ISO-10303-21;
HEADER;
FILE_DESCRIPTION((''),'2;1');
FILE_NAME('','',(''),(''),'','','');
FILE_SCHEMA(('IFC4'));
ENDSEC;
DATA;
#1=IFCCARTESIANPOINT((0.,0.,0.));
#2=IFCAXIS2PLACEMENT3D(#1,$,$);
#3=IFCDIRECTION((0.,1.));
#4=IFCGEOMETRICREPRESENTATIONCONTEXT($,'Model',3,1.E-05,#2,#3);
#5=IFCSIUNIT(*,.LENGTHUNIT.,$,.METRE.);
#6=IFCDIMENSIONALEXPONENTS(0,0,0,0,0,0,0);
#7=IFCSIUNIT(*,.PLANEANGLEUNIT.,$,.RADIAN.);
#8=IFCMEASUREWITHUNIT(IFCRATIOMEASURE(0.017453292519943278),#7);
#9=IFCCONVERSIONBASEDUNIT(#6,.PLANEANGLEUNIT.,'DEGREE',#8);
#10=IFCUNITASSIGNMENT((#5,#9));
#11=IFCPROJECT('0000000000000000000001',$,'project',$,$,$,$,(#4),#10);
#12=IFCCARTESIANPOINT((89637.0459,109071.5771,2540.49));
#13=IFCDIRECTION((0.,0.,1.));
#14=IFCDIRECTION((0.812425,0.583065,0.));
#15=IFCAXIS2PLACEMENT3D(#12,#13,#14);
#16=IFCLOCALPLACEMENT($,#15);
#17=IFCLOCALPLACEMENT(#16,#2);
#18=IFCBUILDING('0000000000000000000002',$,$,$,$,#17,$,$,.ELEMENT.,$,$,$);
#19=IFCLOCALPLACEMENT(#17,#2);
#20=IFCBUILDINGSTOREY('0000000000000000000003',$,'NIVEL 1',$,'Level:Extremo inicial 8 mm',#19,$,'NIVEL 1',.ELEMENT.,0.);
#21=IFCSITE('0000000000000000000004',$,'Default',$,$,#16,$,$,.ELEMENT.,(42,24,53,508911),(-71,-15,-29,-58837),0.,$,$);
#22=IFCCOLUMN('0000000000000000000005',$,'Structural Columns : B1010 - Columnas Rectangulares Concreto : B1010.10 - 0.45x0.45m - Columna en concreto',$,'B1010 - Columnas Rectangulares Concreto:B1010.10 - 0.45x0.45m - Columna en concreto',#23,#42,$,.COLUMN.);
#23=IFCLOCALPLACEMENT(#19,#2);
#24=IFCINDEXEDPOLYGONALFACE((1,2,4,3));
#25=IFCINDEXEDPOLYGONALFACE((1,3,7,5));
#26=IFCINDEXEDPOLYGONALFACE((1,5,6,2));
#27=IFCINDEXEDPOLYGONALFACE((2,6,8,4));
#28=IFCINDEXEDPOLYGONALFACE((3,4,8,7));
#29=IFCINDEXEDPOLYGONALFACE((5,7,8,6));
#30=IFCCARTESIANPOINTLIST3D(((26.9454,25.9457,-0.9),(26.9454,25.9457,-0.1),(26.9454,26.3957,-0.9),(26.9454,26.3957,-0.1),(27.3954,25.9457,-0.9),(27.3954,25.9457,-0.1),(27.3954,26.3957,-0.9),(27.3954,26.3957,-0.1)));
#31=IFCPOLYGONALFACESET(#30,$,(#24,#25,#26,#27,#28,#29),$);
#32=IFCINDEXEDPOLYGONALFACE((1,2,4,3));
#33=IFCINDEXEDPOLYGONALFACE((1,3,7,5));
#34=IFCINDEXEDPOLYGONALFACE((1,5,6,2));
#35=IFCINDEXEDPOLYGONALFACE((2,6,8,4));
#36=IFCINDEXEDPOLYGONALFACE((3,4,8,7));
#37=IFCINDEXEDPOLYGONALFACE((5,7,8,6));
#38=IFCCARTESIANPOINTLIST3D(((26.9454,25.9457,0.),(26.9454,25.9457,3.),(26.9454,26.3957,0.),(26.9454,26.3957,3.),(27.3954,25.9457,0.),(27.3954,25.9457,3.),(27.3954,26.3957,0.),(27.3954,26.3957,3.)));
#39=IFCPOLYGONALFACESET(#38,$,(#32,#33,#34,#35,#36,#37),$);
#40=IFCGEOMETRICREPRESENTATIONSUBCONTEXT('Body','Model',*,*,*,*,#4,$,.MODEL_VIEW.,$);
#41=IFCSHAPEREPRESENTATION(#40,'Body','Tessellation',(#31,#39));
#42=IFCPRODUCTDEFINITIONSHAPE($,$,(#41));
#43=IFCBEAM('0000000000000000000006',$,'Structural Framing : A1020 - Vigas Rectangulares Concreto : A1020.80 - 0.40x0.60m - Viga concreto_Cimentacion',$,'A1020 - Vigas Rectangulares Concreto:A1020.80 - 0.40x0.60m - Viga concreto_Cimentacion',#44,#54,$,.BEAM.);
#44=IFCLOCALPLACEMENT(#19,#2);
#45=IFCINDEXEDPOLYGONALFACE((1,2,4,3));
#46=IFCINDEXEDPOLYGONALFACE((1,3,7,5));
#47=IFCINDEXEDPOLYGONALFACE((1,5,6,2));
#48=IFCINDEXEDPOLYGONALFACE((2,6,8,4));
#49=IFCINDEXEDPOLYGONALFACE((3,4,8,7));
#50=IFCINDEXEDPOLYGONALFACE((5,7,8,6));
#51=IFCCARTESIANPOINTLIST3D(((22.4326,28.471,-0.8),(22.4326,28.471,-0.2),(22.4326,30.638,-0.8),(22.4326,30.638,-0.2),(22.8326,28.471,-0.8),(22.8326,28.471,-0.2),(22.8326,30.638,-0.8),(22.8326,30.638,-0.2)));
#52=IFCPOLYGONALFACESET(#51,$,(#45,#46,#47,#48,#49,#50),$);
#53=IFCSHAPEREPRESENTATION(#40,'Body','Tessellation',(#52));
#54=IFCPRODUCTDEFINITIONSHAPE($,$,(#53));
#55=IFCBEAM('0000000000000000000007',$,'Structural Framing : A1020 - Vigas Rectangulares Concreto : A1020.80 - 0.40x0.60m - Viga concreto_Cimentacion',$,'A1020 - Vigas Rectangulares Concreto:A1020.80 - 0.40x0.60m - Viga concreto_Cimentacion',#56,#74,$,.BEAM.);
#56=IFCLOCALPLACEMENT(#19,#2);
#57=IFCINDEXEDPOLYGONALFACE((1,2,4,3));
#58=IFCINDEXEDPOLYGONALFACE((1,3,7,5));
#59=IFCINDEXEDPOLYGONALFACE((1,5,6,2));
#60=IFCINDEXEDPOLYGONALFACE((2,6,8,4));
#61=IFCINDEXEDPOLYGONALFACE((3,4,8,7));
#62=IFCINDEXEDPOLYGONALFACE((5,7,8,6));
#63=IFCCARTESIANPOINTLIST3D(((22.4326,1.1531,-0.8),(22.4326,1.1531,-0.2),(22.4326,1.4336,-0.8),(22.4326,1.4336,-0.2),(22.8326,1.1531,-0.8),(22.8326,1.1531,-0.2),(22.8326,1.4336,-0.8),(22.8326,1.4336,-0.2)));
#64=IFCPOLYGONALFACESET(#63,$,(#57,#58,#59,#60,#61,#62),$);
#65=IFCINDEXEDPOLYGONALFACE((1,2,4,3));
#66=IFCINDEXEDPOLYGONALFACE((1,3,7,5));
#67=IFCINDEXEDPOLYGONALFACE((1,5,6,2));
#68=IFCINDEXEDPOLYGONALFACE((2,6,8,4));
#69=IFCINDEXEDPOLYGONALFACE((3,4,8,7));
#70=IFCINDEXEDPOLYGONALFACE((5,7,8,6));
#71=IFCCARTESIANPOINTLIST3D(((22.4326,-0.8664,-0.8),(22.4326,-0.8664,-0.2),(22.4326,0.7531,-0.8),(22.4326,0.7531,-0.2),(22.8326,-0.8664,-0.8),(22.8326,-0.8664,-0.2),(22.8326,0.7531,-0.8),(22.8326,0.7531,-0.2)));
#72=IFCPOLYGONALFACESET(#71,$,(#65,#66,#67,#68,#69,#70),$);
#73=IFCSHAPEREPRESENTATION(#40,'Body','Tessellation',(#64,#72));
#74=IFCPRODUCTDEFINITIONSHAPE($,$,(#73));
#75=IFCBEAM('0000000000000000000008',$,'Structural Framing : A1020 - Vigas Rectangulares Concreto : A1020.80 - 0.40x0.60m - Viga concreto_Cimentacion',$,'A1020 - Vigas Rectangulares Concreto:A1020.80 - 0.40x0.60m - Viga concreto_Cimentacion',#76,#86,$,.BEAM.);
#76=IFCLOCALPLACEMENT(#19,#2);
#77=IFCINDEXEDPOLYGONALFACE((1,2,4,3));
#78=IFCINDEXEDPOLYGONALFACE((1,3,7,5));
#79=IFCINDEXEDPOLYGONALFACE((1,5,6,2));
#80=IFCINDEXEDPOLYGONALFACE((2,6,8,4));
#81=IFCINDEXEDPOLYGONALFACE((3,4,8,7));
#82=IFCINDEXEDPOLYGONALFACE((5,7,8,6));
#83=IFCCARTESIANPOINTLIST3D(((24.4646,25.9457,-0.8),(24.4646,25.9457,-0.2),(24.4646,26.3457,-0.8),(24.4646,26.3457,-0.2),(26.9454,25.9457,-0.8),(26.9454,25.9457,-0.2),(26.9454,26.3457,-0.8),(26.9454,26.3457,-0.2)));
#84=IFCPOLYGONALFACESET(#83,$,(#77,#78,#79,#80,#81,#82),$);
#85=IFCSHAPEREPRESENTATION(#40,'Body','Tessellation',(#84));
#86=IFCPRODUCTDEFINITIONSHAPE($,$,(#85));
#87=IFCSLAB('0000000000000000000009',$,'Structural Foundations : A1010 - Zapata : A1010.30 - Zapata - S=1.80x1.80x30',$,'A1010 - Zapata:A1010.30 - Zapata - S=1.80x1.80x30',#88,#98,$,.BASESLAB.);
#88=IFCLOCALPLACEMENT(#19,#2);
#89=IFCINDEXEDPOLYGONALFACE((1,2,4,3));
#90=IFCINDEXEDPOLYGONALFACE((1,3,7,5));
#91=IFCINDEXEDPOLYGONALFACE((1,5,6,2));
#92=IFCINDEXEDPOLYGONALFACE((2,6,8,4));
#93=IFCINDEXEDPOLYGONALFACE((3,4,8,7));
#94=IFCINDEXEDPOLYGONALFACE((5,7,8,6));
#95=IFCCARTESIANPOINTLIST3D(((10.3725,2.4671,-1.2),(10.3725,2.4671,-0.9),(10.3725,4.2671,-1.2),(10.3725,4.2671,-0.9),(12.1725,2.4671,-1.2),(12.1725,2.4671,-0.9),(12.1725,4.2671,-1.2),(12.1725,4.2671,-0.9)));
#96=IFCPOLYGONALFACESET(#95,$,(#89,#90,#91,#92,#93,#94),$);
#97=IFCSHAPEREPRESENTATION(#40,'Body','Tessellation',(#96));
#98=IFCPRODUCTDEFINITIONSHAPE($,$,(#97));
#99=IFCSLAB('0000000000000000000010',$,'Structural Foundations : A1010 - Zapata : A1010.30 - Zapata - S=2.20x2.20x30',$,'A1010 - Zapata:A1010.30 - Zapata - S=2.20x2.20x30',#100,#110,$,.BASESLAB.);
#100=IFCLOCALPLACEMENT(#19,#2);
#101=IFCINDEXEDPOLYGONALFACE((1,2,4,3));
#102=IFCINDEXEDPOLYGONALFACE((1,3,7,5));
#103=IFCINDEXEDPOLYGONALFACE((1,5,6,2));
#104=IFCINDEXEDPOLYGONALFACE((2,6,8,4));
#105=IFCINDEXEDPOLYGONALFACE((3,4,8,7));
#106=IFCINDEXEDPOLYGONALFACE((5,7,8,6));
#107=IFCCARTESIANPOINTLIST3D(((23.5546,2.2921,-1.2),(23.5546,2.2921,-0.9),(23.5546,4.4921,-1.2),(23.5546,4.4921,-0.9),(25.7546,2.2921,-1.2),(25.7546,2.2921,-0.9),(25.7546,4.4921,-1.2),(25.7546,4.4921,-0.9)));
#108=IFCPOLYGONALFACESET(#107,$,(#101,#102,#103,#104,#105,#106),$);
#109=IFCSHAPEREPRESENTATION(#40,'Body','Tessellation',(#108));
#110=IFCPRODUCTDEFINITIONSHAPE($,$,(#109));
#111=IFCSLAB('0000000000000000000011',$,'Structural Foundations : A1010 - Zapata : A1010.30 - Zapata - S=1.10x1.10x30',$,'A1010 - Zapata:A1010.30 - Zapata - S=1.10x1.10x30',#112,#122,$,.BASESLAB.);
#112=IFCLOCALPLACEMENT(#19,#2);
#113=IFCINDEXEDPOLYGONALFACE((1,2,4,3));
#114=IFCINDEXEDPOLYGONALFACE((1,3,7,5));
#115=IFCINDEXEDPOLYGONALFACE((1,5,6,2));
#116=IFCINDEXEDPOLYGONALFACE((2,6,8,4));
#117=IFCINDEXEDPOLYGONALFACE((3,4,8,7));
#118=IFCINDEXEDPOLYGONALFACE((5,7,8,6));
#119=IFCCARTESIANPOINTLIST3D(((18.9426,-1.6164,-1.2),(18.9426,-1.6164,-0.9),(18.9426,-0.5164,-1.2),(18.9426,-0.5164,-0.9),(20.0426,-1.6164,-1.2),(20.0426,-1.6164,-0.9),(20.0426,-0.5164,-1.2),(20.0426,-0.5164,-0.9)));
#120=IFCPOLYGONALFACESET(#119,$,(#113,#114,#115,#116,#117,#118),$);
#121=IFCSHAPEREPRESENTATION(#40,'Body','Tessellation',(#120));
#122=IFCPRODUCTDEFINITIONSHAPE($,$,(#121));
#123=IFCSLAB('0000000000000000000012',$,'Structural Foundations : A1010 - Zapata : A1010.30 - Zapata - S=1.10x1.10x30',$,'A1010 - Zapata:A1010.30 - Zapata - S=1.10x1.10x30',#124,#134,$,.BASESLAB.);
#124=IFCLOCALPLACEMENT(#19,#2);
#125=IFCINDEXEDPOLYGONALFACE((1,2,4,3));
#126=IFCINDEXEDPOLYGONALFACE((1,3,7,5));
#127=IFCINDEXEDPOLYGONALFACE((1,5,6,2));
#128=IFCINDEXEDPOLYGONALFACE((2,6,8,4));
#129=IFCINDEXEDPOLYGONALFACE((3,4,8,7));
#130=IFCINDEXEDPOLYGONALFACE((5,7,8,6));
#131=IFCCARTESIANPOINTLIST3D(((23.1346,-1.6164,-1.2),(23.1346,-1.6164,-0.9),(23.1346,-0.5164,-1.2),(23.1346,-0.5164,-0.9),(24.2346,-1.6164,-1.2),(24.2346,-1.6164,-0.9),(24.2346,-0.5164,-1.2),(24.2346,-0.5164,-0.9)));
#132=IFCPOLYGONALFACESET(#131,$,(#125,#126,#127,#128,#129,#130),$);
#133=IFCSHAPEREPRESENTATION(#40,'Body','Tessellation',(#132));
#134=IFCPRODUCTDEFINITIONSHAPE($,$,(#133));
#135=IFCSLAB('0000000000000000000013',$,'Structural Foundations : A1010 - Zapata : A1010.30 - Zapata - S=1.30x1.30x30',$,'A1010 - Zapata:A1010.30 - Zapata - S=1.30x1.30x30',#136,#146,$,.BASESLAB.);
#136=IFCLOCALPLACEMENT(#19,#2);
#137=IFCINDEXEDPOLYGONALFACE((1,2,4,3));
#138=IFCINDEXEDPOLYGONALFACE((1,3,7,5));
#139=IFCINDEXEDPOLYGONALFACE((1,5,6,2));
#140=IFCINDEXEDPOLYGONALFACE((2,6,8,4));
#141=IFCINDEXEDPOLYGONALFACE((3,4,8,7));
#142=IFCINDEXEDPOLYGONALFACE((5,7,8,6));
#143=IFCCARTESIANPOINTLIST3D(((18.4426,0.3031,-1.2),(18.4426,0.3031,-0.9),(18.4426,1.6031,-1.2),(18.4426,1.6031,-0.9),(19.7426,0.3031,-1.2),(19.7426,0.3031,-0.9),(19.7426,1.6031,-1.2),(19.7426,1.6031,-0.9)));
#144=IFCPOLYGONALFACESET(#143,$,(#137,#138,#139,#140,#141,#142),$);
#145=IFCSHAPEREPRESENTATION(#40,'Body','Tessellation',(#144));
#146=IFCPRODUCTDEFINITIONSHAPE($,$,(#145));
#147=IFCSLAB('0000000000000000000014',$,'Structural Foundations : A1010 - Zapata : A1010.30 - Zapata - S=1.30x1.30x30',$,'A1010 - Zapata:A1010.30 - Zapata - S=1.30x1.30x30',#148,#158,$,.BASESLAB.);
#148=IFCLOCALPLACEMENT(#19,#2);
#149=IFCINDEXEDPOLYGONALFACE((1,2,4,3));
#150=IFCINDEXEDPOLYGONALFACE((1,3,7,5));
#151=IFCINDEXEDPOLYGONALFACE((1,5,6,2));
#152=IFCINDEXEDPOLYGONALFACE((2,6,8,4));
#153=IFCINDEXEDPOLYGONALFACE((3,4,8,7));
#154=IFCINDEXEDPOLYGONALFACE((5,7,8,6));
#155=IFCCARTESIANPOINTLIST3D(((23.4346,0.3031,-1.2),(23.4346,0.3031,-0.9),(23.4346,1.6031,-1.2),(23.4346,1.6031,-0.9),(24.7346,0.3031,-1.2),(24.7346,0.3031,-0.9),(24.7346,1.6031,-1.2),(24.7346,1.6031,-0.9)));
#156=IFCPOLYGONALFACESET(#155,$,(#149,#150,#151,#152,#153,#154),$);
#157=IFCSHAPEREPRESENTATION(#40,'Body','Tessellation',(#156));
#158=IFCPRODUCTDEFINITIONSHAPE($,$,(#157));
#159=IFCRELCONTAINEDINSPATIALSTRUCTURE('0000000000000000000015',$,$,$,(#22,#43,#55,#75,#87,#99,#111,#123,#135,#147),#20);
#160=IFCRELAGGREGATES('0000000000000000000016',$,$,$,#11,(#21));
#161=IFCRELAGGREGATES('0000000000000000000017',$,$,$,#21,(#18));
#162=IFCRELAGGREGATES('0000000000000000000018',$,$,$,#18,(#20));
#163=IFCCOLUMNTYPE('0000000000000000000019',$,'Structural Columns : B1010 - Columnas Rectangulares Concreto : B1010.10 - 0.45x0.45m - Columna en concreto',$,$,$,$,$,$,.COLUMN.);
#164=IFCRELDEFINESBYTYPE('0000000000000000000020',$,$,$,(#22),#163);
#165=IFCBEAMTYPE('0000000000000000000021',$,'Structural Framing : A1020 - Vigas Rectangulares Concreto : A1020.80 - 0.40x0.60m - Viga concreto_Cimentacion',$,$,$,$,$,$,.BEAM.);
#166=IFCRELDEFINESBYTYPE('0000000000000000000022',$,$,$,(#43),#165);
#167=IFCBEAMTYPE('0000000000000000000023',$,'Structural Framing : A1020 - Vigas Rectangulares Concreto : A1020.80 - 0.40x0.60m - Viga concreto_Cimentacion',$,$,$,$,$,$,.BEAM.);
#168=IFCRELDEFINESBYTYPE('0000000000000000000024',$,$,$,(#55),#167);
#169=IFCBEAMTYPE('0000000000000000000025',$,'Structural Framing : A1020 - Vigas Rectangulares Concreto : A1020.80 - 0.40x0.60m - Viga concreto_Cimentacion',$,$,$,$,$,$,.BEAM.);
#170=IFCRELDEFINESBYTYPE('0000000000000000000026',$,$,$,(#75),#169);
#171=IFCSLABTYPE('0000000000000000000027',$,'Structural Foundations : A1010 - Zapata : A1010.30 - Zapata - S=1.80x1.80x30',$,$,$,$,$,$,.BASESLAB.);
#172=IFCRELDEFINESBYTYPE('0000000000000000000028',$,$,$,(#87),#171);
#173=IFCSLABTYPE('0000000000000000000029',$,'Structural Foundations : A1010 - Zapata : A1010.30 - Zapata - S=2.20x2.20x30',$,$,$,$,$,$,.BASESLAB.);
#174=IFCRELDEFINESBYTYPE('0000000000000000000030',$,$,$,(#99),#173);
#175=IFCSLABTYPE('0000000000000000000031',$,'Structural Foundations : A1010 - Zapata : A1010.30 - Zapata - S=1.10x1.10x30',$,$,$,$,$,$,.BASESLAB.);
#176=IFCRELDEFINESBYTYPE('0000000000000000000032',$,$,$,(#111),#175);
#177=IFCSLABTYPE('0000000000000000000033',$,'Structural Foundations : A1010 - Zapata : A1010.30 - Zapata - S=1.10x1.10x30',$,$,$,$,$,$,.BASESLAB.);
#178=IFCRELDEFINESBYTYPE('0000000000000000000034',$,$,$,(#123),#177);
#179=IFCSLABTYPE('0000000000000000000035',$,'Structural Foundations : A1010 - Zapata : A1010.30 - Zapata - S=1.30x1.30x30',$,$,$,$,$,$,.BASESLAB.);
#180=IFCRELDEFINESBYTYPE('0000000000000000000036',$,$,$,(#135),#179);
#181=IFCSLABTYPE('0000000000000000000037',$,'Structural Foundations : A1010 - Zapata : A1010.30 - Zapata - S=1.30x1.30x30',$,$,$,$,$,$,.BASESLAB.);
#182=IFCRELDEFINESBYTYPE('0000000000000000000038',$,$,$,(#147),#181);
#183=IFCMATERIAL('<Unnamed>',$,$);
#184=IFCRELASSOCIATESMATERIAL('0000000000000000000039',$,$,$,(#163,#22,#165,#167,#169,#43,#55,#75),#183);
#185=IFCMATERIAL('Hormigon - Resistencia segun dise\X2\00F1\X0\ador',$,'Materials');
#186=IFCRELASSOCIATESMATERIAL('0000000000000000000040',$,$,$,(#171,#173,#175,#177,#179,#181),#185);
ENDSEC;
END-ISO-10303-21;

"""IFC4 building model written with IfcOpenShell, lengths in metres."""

from ifc_helpers import new_model, entity, si_unit, converted_unit, direction, frame, frame_2d, origin, origin_2d_with_axis, place, context, subcontext, project, spatial, polyline, segment, composite_curve, rectangle, outline, extrude, source, transform, mapped, material, material_profile, profile_set, profile_usage, type_object, type_shapes, element, save


model = new_model("IFC4")

# Units and contexts
model_context = context("Model", 3, precision=1e-05, world=origin(), true_north=direction((0.0, 1.0)))
body_context = subcontext(model_context, "Body", "Model", "MODEL_VIEW")
ifc_project = project(units=[si_unit("LENGTHUNIT", "METRE"), converted_unit("PLANEANGLEUNIT", "DEGREE", entity("IfcRatioMeasure", 0.017453292519943278), si_unit("PLANEANGLEUNIT", "RADIAN"), dimensions=[0, 0, 0, 0, 0, 0, 0])], contexts=[model_context])

# Site, building, storey
site_placement = place(None, frame((89637.0459, 109071.5771, 2540.49), z_axis=(0.0, 0.0, 1.0), x_axis=(0.812425, 0.583065, 0.0)))
site = spatial("IfcSite", under=ifc_project, at=site_placement, Name="Default", CompositionType="ELEMENT", RefLatitude=(42, 24, 53, 508911), RefLongitude=(-71, -15, -29, -58837), RefElevation=0.0)
building_placement = place(site_placement, origin())
building = spatial("IfcBuilding", under=site, at=building_placement, CompositionType="ELEMENT")
storey_placement = place(building_placement, origin())
storey = spatial("IfcBuildingStorey", under=building, at=storey_placement, Name="NIVEL 1", ObjectType="Level:Extremo inicial 8 mm", LongName="NIVEL 1", CompositionType="ELEMENT", Elevation=0.0)

# Column
ifc_material_1 = material(Name="<Unnamed>")
ifc_material_profile_1 = material_profile(ifc_material_1, outline(composite_curve([segment(polyline([(0.225, 0.225, 0.0), (0.225, -0.225, 0.0)]), True, "CONTINUOUS"), segment(polyline([(0.225, -0.225, 0.0), (-0.225, -0.225, 0.0)]), True, "CONTINUOUS"), segment(polyline([(-0.225, -0.225, 0.0), (-0.225, 0.225, 0.0)]), True, "CONTINUOUS"), segment(polyline([(-0.225, 0.225, 0.0), (0.225, 0.225, 0.0)]), True, "CONTINUOUS")], self_intersect=False), kind="CURVE"), Name="B1010.10 - 0.45x0.45m - Columna en concreto")
ifc_material_profile_2 = material_profile(ifc_material_1, outline(composite_curve([segment(polyline([(0.225, 0.225, 3.0), (-0.225, 0.225, 3.0)]), True, "CONTINUOUS"), segment(polyline([(-0.225, 0.225, 3.0), (-0.225, -0.225, 3.0)]), True, "CONTINUOUS"), segment(polyline([(-0.225, -0.225, 3.0), (0.225, -0.225, 3.0)]), True, "CONTINUOUS"), segment(polyline([(0.225, -0.225, 3.0), (0.225, 0.225, 3.0)]), True, "CONTINUOUS")], self_intersect=False), kind="CURVE"), Name="B1010.10 - 0.45x0.45m - Columna en concreto")
ifc_profile_set_1 = profile_set([ifc_material_profile_1, ifc_material_profile_2], Name="B1010.10 - 0.45x0.45m - Columna en concreto")
ifc_profile_usage_1 = profile_usage(ifc_profile_set_1)
column_type = type_object("IfcColumnType", Name="Structural Columns : B1010 - Columnas Rectangulares Concreto : B1010.10 - 0.45x0.45m - Columna en concreto", PredefinedType="COLUMN", material=ifc_profile_set_1)
shared_shape_1 = source(origin(), body_context, "Body", "SweptSolid", [
    extrude(rectangle(XDim=0.45, YDim=0.45, at=origin_2d_with_axis()), frame((27.1704, 26.1707, -0.9), z_axis=(0.0, 0.0, 1.0), x_axis=(0.0, -1.0, 0.0)), (0.0, 0.0, 1.0), 0.8),
    extrude(rectangle(XDim=0.45, YDim=0.45, at=origin_2d_with_axis()), frame((27.1704, 26.1707, 0.0), z_axis=(0.0, 0.0, 1.0), x_axis=(0.0, -1.0, 0.0)), (0.0, 0.0, 1.0), 3.0),
])
type_shapes(column_type, [shared_shape_1])
column_placement = place(storey_placement, origin())
element("IfcColumn", 1, at=column_placement, inside=storey, type_object=column_type, material=ifc_profile_usage_1, Name="Structural Columns : B1010 - Columnas Rectangulares Concreto : B1010.10 - 0.45x0.45m - Columna en concreto", ObjectType="B1010 - Columnas Rectangulares Concreto:B1010.10 - 0.45x0.45m - Columna en concreto", PredefinedType="COLUMN", context=body_context, shape_type="MappedRepresentation", body=[
    mapped(shared_shape_1, transform((0.0, 0.0, 0.0), scale=1.0)),
])

# Beams
ifc_material_profile_3 = material_profile(ifc_material_1, outline(composite_curve([segment(polyline([(-0.2, 0.3, 0.0), (0.2, 0.3, 0.0)]), True, "CONTINUOUS"), segment(polyline([(0.2, 0.3, 0.0), (0.2, -0.3, 0.0)]), True, "CONTINUOUS"), segment(polyline([(0.2, -0.3, 0.0), (-0.2, -0.3, 0.0)]), True, "CONTINUOUS"), segment(polyline([(-0.2, -0.3, 0.0), (-0.2, 0.3, 0.0)]), True, "CONTINUOUS")], self_intersect=False), kind="CURVE"), Name="A1020.80 - 0.40x0.60m - Viga concreto_Cimentacion")
ifc_material_profile_4 = material_profile(ifc_material_1, outline(composite_curve([segment(polyline([(6.4409, -0.2, 0.3), (6.4409, -0.2, -0.3)]), True, "CONTINUOUS"), segment(polyline([(6.4409, -0.2, -0.3), (6.4409, 0.2, -0.3)]), True, "CONTINUOUS"), segment(polyline([(6.4409, 0.2, -0.3), (6.4409, 0.2, 0.3)]), True, "CONTINUOUS"), segment(polyline([(6.4409, 0.2, 0.3), (6.4409, -0.2, 0.3)]), True, "CONTINUOUS")], self_intersect=False), kind="CURVE"), Name="A1020.80 - 0.40x0.60m - Viga concreto_Cimentacion")
ifc_profile_set_2 = profile_set([ifc_material_profile_3, ifc_material_profile_4], Name="A1020.80 - 0.40x0.60m - Viga concreto_Cimentacion")
ifc_profile_usage_2 = profile_usage(ifc_profile_set_2, cardinal=8)
beam_type_1 = type_object("IfcBeamType", Name="Structural Framing : A1020 - Vigas Rectangulares Concreto : A1020.80 - 0.40x0.60m - Viga concreto_Cimentacion", PredefinedType="BEAM", material=ifc_profile_set_2)
shared_shape_2 = source(origin(), body_context, "Body", "SweptSolid", [
    extrude(rectangle(XDim=0.6, YDim=0.4, at=frame_2d((0.0, 0.0), x_axis=(0.0, 1.0))), frame((22.6326, 28.471, -0.5), z_axis=(0.0, 1.0, 0.0), x_axis=(-1.0, 0.0, 0.0)), (0.0, 0.0, 1.0), 2.1671),
])
type_shapes(beam_type_1, [shared_shape_2])
beam_1_placement = place(storey_placement, origin())
element("IfcBeam", 2, at=beam_1_placement, inside=storey, type_object=beam_type_1, material=ifc_profile_usage_2, Name="Structural Framing : A1020 - Vigas Rectangulares Concreto : A1020.80 - 0.40x0.60m - Viga concreto_Cimentacion", ObjectType="A1020 - Vigas Rectangulares Concreto:A1020.80 - 0.40x0.60m - Viga concreto_Cimentacion", PredefinedType="BEAM", context=body_context, shape_type="MappedRepresentation", body=[
    mapped(shared_shape_2, transform((0.0, 0.0, 0.0), scale=1.0)),
])
ifc_profile_usage_3 = profile_usage(ifc_profile_set_2, cardinal=8)
beam_type_2 = type_object("IfcBeamType", Name="Structural Framing : A1020 - Vigas Rectangulares Concreto : A1020.80 - 0.40x0.60m - Viga concreto_Cimentacion", PredefinedType="BEAM", material=ifc_profile_set_2)
shared_shape_3 = source(origin(), body_context, "Body", "SweptSolid", [
    extrude(rectangle(XDim=0.6, YDim=0.4, at=frame_2d((0.0, 0.0), x_axis=(0.0, 1.0))), frame((22.6326, 1.1531, -0.5), z_axis=(0.0, 1.0, 0.0), x_axis=(-1.0, 0.0, 0.0)), (0.0, 0.0, 1.0), 0.2805),
    extrude(rectangle(XDim=0.6, YDim=0.4, at=frame_2d((0.0, 0.0), x_axis=(0.0, 1.0))), frame((22.6326, -0.8664, -0.5), z_axis=(0.0, 1.0, 0.0), x_axis=(-1.0, 0.0, 0.0)), (0.0, 0.0, 1.0), 1.6195),
])
type_shapes(beam_type_2, [shared_shape_3])
beam_2_placement = place(storey_placement, origin())
element("IfcBeam", 3, at=beam_2_placement, inside=storey, type_object=beam_type_2, material=ifc_profile_usage_3, Name="Structural Framing : A1020 - Vigas Rectangulares Concreto : A1020.80 - 0.40x0.60m - Viga concreto_Cimentacion", ObjectType="A1020 - Vigas Rectangulares Concreto:A1020.80 - 0.40x0.60m - Viga concreto_Cimentacion", PredefinedType="BEAM", context=body_context, shape_type="MappedRepresentation", body=[
    mapped(shared_shape_3, transform((0.0, 0.0, 0.0), scale=1.0)),
])
ifc_profile_usage_4 = profile_usage(ifc_profile_set_2, cardinal=8)
beam_type_3 = type_object("IfcBeamType", Name="Structural Framing : A1020 - Vigas Rectangulares Concreto : A1020.80 - 0.40x0.60m - Viga concreto_Cimentacion", PredefinedType="BEAM", material=ifc_profile_set_2)
shared_shape_4 = source(origin(), body_context, "Body", "SweptSolid", [
    extrude(rectangle(XDim=0.6, YDim=0.4, at=frame_2d((0.0, 0.0), x_axis=(1.0, 0.0))), frame((24.4646, 26.1457, -0.5), z_axis=(1.0, 0.0, 0.0), x_axis=(0.0, 0.0, -1.0)), (0.0, 0.0, 1.0), 2.4808),
])
type_shapes(beam_type_3, [shared_shape_4])
beam_3_placement = place(storey_placement, origin())
element("IfcBeam", 4, at=beam_3_placement, inside=storey, type_object=beam_type_3, material=ifc_profile_usage_4, Name="Structural Framing : A1020 - Vigas Rectangulares Concreto : A1020.80 - 0.40x0.60m - Viga concreto_Cimentacion", ObjectType="A1020 - Vigas Rectangulares Concreto:A1020.80 - 0.40x0.60m - Viga concreto_Cimentacion", PredefinedType="BEAM", context=body_context, shape_type="MappedRepresentation", body=[
    mapped(shared_shape_4, transform((0.0, 0.0, 0.0), scale=1.0)),
])

# Slabs
ifc_material_2 = material(Name="Hormigon - Resistencia segun diseñador", Category="Materials")
slab_type_1 = type_object("IfcSlabType", Name="Structural Foundations : A1010 - Zapata : A1010.30 - Zapata - S=1.80x1.80x30", PredefinedType="BASESLAB", material=ifc_material_2)
slab_1_placement = place(storey_placement, frame((10.3725, 2.4671, -1.2)))
element("IfcSlab", 5, at=slab_1_placement, inside=storey, type_object=slab_type_1, Name="Structural Foundations : A1010 - Zapata : A1010.30 - Zapata - S=1.80x1.80x30", ObjectType="A1010 - Zapata:A1010.30 - Zapata - S=1.80x1.80x30", PredefinedType="BASESLAB", context=body_context, shape_type="SweptSolid", body=[
    extrude(rectangle(XDim=1.8, YDim=1.8, at=frame_2d((0.0, 0.0), x_axis=(1.0, 0.0))), frame((0.9, 0.9, 0.0), z_axis=(0.0, 0.0, 1.0), x_axis=(-1.0, 0.0, 0.0)), (0.0, 0.0, 1.0), 0.3),
])
slab_type_2 = type_object("IfcSlabType", Name="Structural Foundations : A1010 - Zapata : A1010.30 - Zapata - S=2.20x2.20x30", PredefinedType="BASESLAB", material=ifc_material_2)
slab_2_placement = place(storey_placement, frame((23.5546, 2.2921, -1.2)))
element("IfcSlab", 6, at=slab_2_placement, inside=storey, type_object=slab_type_2, Name="Structural Foundations : A1010 - Zapata : A1010.30 - Zapata - S=2.20x2.20x30", ObjectType="A1010 - Zapata:A1010.30 - Zapata - S=2.20x2.20x30", PredefinedType="BASESLAB", context=body_context, shape_type="SweptSolid", body=[
    extrude(rectangle(XDim=2.2, YDim=2.2, at=frame_2d((0.0, 0.0), x_axis=(1.0, 0.0))), frame((1.1, 1.1, 0.0), z_axis=(0.0, 0.0, 1.0), x_axis=(-1.0, 0.0, 0.0)), (0.0, 0.0, 1.0), 0.3),
])
slab_type_3 = type_object("IfcSlabType", Name="Structural Foundations : A1010 - Zapata : A1010.30 - Zapata - S=1.10x1.10x30", PredefinedType="BASESLAB", material=ifc_material_2)
slab_3_placement = place(storey_placement, frame((18.9426, -1.6164, -1.2)))
element("IfcSlab", 7, at=slab_3_placement, inside=storey, type_object=slab_type_3, Name="Structural Foundations : A1010 - Zapata : A1010.30 - Zapata - S=1.10x1.10x30", ObjectType="A1010 - Zapata:A1010.30 - Zapata - S=1.10x1.10x30", PredefinedType="BASESLAB", context=body_context, shape_type="SweptSolid", body=[
    extrude(rectangle(XDim=1.1, YDim=1.1, at=frame_2d((0.0, 0.0), x_axis=(1.0, 0.0))), frame((0.55, 0.55, 0.0), z_axis=(0.0, 0.0, 1.0), x_axis=(-1.0, 0.0, 0.0)), (0.0, 0.0, 1.0), 0.3),
])
slab_type_4 = type_object("IfcSlabType", Name="Structural Foundations : A1010 - Zapata : A1010.30 - Zapata - S=1.10x1.10x30", PredefinedType="BASESLAB", material=ifc_material_2)
slab_4_placement = place(storey_placement, frame((23.1346, -1.6164, -1.2)))
element("IfcSlab", 8, at=slab_4_placement, inside=storey, type_object=slab_type_4, Name="Structural Foundations : A1010 - Zapata : A1010.30 - Zapata - S=1.10x1.10x30", ObjectType="A1010 - Zapata:A1010.30 - Zapata - S=1.10x1.10x30", PredefinedType="BASESLAB", context=body_context, shape_type="SweptSolid", body=[
    extrude(rectangle(XDim=1.1, YDim=1.1, at=frame_2d((0.0, 0.0), x_axis=(1.0, 0.0))), frame((0.55, 0.55, 0.0), z_axis=(0.0, 0.0, 1.0), x_axis=(-1.0, 0.0, 0.0)), (0.0, 0.0, 1.0), 0.3),
])
slab_type_5 = type_object("IfcSlabType", Name="Structural Foundations : A1010 - Zapata : A1010.30 - Zapata - S=1.30x1.30x30", PredefinedType="BASESLAB", material=ifc_material_2)
slab_5_placement = place(storey_placement, frame((18.4426, 0.3031, -1.2)))
element("IfcSlab", 9, at=slab_5_placement, inside=storey, type_object=slab_type_5, Name="Structural Foundations : A1010 - Zapata : A1010.30 - Zapata - S=1.30x1.30x30", ObjectType="A1010 - Zapata:A1010.30 - Zapata - S=1.30x1.30x30", PredefinedType="BASESLAB", context=body_context, shape_type="SweptSolid", body=[
    extrude(rectangle(XDim=1.3, YDim=1.3, at=frame_2d((0.0, 0.0), x_axis=(1.0, 0.0))), frame((0.65, 0.65, 0.0), z_axis=(0.0, 0.0, 1.0), x_axis=(-1.0, 0.0, 0.0)), (0.0, 0.0, 1.0), 0.3),
])
slab_type_6 = type_object("IfcSlabType", Name="Structural Foundations : A1010 - Zapata : A1010.30 - Zapata - S=1.30x1.30x30", PredefinedType="BASESLAB", material=ifc_material_2)
slab_6_placement = place(storey_placement, frame((23.4346, 0.3031, -1.2)))
element("IfcSlab", 10, at=slab_6_placement, inside=storey, type_object=slab_type_6, Name="Structural Foundations : A1010 - Zapata : A1010.30 - Zapata - S=1.30x1.30x30", ObjectType="A1010 - Zapata:A1010.30 - Zapata - S=1.30x1.30x30", PredefinedType="BASESLAB", context=body_context, shape_type="SweptSolid", body=[
    extrude(rectangle(XDim=1.3, YDim=1.3, at=frame_2d((0.0, 0.0), x_axis=(1.0, 0.0))), frame((0.65, 0.65, 0.0), z_axis=(0.0, 0.0, 1.0), x_axis=(-1.0, 0.0, 0.0)), (0.0, 0.0, 1.0), 0.3),
])

save(model, "model.ifc")
